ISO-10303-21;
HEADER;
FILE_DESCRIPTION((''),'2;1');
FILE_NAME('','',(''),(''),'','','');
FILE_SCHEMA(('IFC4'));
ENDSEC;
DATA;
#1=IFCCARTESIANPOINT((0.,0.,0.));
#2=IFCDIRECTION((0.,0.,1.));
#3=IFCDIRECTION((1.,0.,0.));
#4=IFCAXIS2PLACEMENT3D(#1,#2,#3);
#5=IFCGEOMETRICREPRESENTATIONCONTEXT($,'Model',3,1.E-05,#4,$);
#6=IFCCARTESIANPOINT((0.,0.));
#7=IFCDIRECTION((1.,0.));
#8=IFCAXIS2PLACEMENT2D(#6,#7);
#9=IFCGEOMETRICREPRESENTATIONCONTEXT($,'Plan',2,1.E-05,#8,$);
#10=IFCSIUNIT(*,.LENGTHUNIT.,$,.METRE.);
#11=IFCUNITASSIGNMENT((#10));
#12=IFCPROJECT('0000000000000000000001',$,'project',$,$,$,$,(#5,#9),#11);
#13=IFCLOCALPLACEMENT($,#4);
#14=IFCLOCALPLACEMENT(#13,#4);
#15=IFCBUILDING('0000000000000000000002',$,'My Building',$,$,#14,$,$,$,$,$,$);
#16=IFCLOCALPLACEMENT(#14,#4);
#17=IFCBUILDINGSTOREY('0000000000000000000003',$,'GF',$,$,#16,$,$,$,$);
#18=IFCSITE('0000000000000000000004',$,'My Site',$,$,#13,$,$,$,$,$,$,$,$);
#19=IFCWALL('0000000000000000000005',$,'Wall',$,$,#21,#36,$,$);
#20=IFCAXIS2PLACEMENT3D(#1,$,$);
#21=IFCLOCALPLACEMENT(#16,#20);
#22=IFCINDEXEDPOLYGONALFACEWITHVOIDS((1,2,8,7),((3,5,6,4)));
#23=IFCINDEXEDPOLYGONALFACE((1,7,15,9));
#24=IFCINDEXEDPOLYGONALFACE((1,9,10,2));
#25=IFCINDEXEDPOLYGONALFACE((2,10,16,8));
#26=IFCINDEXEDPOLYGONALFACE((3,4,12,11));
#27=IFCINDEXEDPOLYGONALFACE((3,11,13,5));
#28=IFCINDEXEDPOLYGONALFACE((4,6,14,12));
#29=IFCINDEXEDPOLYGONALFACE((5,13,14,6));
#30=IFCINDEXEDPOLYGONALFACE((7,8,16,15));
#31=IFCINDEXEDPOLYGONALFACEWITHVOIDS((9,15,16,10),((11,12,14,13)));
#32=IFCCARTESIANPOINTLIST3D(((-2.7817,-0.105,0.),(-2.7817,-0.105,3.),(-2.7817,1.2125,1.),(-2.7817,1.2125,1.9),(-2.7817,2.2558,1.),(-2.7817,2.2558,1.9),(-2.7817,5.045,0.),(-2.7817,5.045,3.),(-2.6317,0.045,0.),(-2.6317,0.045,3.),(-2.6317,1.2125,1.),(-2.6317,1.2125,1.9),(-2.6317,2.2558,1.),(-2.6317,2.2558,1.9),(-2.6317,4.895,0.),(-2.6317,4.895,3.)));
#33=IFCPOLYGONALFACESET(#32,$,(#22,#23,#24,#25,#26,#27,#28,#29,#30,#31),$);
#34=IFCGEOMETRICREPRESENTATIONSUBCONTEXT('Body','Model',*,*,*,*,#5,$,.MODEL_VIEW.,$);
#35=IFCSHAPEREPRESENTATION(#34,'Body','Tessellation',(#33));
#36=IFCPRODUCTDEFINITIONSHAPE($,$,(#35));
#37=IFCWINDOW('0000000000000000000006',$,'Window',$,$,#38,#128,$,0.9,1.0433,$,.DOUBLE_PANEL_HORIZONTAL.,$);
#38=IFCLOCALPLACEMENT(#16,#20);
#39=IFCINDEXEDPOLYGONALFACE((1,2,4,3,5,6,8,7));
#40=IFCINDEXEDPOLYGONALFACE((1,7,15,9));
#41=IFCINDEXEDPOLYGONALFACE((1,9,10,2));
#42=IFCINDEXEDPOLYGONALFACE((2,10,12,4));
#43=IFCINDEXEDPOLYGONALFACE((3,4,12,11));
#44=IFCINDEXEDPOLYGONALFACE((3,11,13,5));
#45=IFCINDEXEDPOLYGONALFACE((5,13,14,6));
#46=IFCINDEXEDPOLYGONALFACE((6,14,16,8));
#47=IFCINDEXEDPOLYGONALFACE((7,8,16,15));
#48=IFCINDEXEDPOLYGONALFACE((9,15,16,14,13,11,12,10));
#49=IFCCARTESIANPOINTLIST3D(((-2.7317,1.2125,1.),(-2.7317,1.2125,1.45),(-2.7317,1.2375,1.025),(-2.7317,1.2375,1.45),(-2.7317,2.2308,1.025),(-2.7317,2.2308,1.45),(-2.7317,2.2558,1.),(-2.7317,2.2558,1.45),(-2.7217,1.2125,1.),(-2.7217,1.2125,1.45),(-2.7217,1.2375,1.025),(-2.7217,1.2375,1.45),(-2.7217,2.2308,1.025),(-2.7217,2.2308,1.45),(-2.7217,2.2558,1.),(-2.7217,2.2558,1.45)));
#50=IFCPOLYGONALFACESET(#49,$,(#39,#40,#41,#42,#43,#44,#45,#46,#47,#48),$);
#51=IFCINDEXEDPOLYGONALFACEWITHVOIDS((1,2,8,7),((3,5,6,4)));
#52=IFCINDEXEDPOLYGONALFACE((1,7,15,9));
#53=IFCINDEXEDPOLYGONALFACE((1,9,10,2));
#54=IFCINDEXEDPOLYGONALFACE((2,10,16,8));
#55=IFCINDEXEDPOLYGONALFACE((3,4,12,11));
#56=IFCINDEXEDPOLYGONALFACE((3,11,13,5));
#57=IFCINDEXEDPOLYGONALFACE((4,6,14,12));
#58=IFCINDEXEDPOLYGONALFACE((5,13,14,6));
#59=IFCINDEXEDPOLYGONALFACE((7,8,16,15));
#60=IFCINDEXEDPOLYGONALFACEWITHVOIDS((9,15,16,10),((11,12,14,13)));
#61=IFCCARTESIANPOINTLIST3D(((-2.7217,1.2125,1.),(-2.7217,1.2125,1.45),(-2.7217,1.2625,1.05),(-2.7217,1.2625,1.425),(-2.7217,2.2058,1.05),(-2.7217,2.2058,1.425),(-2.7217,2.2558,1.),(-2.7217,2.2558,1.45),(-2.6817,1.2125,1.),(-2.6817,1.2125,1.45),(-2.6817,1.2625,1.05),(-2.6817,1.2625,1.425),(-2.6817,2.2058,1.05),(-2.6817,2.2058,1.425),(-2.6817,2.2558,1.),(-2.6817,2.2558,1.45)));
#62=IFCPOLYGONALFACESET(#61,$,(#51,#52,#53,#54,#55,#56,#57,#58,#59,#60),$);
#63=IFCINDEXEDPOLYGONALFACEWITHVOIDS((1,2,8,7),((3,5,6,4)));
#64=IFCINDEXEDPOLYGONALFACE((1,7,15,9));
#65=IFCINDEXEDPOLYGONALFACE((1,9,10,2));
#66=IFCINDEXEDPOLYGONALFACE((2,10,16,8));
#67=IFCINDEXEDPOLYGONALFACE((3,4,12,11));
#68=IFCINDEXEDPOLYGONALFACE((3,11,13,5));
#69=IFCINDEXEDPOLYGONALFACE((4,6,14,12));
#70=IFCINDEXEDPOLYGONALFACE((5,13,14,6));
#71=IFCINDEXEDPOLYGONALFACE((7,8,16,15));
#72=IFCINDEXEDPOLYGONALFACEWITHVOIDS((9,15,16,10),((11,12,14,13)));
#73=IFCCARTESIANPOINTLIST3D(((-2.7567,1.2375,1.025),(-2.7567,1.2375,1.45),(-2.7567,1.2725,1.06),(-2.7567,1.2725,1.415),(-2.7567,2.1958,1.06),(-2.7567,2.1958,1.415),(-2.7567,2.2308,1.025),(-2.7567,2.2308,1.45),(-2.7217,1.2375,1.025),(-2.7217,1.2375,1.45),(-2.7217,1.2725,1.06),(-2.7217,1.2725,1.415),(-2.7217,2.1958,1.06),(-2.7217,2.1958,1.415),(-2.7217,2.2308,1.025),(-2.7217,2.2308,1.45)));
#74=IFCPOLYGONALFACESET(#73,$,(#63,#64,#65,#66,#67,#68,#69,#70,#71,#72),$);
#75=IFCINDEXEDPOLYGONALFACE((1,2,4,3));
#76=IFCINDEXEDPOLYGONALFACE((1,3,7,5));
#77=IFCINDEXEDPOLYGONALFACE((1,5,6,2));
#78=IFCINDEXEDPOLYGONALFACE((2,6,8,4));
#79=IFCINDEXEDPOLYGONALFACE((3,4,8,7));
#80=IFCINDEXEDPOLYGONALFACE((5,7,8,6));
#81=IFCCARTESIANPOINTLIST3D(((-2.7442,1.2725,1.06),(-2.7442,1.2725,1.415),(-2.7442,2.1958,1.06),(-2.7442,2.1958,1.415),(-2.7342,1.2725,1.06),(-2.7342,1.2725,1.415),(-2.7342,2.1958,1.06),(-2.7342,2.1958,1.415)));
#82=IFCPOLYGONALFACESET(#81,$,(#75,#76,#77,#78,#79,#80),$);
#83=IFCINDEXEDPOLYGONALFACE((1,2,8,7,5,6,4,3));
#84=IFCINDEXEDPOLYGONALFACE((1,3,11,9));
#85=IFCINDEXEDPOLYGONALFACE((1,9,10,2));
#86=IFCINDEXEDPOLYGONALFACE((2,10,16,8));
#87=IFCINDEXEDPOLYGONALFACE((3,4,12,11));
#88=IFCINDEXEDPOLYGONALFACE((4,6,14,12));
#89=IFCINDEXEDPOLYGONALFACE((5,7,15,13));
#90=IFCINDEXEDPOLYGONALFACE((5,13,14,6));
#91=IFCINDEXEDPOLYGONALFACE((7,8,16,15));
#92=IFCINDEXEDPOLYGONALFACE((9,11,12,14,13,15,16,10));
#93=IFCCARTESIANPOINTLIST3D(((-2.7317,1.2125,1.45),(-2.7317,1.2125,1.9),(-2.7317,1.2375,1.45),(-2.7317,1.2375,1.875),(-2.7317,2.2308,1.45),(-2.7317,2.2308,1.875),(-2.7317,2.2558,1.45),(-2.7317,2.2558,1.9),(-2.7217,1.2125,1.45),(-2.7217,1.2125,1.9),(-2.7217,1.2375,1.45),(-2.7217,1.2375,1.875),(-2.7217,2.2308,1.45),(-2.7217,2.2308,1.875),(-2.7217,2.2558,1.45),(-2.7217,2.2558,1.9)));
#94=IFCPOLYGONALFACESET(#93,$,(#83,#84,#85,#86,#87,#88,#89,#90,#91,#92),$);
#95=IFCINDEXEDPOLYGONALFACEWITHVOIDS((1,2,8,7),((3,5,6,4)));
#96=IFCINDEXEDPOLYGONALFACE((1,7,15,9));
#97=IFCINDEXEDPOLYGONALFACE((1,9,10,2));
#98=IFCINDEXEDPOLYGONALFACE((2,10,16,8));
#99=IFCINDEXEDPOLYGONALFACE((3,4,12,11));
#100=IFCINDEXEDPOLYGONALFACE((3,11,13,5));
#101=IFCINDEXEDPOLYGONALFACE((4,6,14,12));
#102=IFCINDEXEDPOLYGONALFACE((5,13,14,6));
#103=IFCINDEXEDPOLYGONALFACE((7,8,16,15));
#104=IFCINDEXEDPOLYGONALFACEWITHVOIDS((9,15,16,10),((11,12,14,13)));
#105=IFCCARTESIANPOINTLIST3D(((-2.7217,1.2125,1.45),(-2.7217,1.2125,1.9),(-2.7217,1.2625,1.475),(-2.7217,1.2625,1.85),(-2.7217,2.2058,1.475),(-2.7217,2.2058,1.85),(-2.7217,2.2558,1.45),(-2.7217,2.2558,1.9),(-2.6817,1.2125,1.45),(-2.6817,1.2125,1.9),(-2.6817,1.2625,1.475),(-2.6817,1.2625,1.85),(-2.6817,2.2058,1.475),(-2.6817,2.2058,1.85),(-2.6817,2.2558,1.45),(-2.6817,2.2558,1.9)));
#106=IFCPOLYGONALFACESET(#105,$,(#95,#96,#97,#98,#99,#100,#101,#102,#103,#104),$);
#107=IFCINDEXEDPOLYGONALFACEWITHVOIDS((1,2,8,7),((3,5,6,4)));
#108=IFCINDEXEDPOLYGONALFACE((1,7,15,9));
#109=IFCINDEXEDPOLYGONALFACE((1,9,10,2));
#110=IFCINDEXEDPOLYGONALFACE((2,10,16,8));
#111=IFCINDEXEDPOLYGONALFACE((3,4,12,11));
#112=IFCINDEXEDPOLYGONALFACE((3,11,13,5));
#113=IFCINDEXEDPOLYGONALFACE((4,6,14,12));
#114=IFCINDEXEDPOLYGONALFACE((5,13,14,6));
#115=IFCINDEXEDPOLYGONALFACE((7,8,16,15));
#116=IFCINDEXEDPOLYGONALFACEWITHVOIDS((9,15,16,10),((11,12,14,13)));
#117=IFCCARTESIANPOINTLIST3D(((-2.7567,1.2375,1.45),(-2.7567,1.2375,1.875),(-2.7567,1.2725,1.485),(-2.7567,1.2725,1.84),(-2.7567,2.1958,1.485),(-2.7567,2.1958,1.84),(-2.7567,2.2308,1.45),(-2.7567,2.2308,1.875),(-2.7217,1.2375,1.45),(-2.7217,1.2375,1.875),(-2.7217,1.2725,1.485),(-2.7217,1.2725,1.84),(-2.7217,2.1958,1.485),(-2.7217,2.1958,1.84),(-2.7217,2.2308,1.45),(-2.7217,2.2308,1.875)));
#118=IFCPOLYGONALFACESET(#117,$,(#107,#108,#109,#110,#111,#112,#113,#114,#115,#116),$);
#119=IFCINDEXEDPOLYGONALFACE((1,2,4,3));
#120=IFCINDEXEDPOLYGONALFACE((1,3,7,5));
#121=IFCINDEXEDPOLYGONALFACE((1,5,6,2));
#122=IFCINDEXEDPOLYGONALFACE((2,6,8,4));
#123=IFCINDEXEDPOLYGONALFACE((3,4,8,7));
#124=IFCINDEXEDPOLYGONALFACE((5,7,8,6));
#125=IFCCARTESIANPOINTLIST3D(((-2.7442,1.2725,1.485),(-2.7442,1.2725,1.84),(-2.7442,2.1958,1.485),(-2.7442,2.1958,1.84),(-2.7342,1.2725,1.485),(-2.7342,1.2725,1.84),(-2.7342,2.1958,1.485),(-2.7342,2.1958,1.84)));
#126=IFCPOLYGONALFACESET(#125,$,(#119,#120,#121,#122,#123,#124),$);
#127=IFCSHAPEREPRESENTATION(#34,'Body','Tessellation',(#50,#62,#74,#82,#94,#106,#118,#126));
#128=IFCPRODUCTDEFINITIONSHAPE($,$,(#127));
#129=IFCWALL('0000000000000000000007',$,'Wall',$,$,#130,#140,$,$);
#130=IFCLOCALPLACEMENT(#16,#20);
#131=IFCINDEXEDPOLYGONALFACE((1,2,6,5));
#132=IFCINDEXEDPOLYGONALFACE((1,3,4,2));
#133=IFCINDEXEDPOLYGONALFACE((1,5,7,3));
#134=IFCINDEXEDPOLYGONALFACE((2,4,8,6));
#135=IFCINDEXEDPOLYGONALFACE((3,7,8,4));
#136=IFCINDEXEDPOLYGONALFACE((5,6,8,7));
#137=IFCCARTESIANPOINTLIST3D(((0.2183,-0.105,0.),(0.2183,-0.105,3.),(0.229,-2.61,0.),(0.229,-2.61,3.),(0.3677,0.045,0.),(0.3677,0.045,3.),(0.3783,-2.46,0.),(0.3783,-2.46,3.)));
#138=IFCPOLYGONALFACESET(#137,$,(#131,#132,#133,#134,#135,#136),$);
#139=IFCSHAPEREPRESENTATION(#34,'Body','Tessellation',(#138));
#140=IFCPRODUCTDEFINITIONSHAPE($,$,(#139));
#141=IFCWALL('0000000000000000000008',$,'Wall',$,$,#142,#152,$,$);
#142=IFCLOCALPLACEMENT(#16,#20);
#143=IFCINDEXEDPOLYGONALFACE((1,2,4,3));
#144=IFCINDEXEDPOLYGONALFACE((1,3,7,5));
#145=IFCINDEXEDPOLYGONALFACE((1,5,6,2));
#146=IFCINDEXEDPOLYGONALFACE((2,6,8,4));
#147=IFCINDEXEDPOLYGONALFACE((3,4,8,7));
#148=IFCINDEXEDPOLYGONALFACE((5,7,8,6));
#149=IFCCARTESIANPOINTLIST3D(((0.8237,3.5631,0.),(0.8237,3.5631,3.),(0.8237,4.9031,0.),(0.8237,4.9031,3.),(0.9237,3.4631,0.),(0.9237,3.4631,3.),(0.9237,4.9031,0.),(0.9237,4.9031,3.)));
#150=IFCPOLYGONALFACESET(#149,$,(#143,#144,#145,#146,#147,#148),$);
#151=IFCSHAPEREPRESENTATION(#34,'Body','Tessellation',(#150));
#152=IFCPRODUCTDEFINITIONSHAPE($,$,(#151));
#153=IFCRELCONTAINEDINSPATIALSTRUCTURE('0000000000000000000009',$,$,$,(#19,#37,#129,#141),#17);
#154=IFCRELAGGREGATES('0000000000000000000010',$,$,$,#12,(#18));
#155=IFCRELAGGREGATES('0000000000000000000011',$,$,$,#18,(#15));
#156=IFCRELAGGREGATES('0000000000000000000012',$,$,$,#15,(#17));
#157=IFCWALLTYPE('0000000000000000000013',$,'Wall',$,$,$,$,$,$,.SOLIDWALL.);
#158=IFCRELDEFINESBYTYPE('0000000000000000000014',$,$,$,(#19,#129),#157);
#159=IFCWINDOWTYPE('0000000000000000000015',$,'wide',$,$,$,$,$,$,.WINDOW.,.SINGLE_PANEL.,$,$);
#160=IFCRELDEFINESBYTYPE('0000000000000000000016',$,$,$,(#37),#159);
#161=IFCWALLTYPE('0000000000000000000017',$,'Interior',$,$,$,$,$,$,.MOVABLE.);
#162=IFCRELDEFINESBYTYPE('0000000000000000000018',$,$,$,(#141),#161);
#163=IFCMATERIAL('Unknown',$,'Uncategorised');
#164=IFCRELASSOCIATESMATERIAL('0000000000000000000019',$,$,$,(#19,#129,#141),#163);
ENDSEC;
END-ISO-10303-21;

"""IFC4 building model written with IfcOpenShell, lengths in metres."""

from ifc_helpers import new_model, entity, si_unit, frame, origin_with_axes, origin_2d_with_axis, place, context, subcontext, project, spatial, line, indexed_curve, outline, extrude, shape, source, transform, mapped, material, type_object, type_shapes, element, fill, save


model = new_model("IFC4")

# Units and contexts
model_context = context("Model", 3, precision=1e-05, world=origin_with_axes())
plan_context = context("Plan", 2, precision=1e-05, world=origin_2d_with_axis())
body_context_1 = subcontext(model_context, "Body", "Model", "MODEL_VIEW")
body_context_2 = subcontext(plan_context, "Body", "Plan", "PLAN_VIEW")
ifc_project = project(units=[si_unit("LENGTHUNIT", "METRE")], contexts=[model_context, plan_context])

# Site, building, storey
site_placement = place(None, origin_with_axes())
site = spatial("IfcSite", under=ifc_project, at=site_placement, Name="My Site")
building_placement = place(site_placement, origin_with_axes())
building = spatial("IfcBuilding", under=site, at=building_placement, Name="My Building")
storey_placement = place(building_placement, origin_with_axes())
storey = spatial("IfcBuildingStorey", under=building, at=storey_placement, Name="GF")

# Shared definitions
ifc_material = material(Name="Unknown", Category="Uncategorised")
wall_type_1 = type_object("IfcWallType", Name="Wall", PredefinedType="SOLIDWALL")
shared_shape_1 = source(origin_with_axes(), body_context_1, "Body", "SweptSolid", [
    extrude(outline(indexed_curve([(0.0, 0.0), (1.0433, 0.0), (1.0433, 0.9), (0.0, 0.9)], segments=[line(1, 2, 3, 4, 1)])), frame((0.0, -0.6, 0.0), z_axis=(0.0, -1.0, 0.0), x_axis=(1.0, 0.0, 0.0)), (0.0, 0.0, -1.0), 1.2),
])
window_type_1 = type_object("IfcWindowType", Name="wide", PartitioningType="SINGLE_PANEL", PredefinedType="WINDOW")
shared_shape_2 = source(origin_with_axes(), body_context_1, "Body", "SweptSolid", [
    extrude(outline(indexed_curve([(1.0433, 0.45), (1.0433, 0.0), (0.0, 0.0), (0.0, 0.45), (0.025, 0.45), (0.025, 0.025), (1.0183, 0.025), (1.0183, 0.45)], segments=[line(1, 2, 3, 4, 5, 6, 7, 8, 1)])), frame((0.0, 0.09, 0.0), z_axis=(0.0, -1.0, 0.0), x_axis=(1.0, 0.0, 0.0)), (0.0, 0.0, -1.0), 0.01),
    extrude(outline(indexed_curve([(0.0, 0.0), (1.0433, 0.0), (1.0433, 0.45), (0.0, 0.45)], segments=[line(1, 2, 3, 4, 1)]), holes=[indexed_curve([(0.05, 0.05), (0.9933, 0.05), (0.9933, 0.425), (0.05, 0.425)], segments=[line(1, 2, 3, 4, 1)])]), frame((0.0, 0.05, 0.0), z_axis=(0.0, -1.0, 0.0), x_axis=(1.0, 0.0, 0.0)), (0.0, 0.0, -1.0), 0.04),
    extrude(outline(indexed_curve([(0.0, 0.0), (0.9933, 0.0), (0.9933, 0.425), (0.0, 0.425)], segments=[line(1, 2, 3, 4, 1)]), holes=[indexed_curve([(0.035, 0.035), (0.9583, 0.035), (0.9583, 0.39), (0.035, 0.39)], segments=[line(1, 2, 3, 4, 1)])]), frame((0.025, 0.09, 0.025), z_axis=(0.0, -1.0, 0.0), x_axis=(1.0, 0.0, 0.0)), (0.0, 0.0, -1.0), 0.035),
    extrude(outline(indexed_curve([(0.035, 0.035), (0.9583, 0.035), (0.9583, 0.39), (0.035, 0.39)], segments=[line(1, 2, 3, 4, 1)])), frame((0.025, 0.1025, 0.025), z_axis=(0.0, -1.0, 0.0), x_axis=(1.0, 0.0, 0.0)), (0.0, 0.0, -1.0), 0.01),
    extrude(outline(indexed_curve([(0.0, 0.0), (0.0, 0.45), (1.0433, 0.45), (1.0433, 0.0), (1.0183, 0.0), (1.0183, 0.425), (0.025, 0.425), (0.025, 0.0)], segments=[line(1, 2, 3, 4, 5, 6, 7, 8, 1)])), frame((0.0, 0.09, 0.45), z_axis=(0.0, -1.0, 0.0), x_axis=(1.0, 0.0, 0.0)), (0.0, 0.0, -1.0), 0.01),
    extrude(outline(indexed_curve([(0.0, 0.0), (1.0433, 0.0), (1.0433, 0.45), (0.0, 0.45)], segments=[line(1, 2, 3, 4, 1)]), holes=[indexed_curve([(0.05, 0.025), (0.9933, 0.025), (0.9933, 0.4), (0.05, 0.4)], segments=[line(1, 2, 3, 4, 1)])]), frame((0.0, 0.05, 0.45), z_axis=(0.0, -1.0, 0.0), x_axis=(1.0, 0.0, 0.0)), (0.0, 0.0, -1.0), 0.04),
    extrude(outline(indexed_curve([(0.0, 0.0), (0.9933, 0.0), (0.9933, 0.425), (0.0, 0.425)], segments=[line(1, 2, 3, 4, 1)]), holes=[indexed_curve([(0.035, 0.035), (0.9583, 0.035), (0.9583, 0.39), (0.035, 0.39)], segments=[line(1, 2, 3, 4, 1)])]), frame((0.025, 0.09, 0.45), z_axis=(0.0, -1.0, 0.0), x_axis=(1.0, 0.0, 0.0)), (0.0, 0.0, -1.0), 0.035),
    extrude(outline(indexed_curve([(0.035, 0.035), (0.9583, 0.035), (0.9583, 0.39), (0.035, 0.39)], segments=[line(1, 2, 3, 4, 1)])), frame((0.025, 0.1025, 0.45), z_axis=(0.0, -1.0, 0.0), x_axis=(1.0, 0.0, 0.0)), (0.0, 0.0, -1.0), 0.01),
])
shared_shape_3 = source(origin_with_axes(), body_context_2, "Body", "Curve2D", [
    entity("IfcIndexedPolyCurve", entity("IfcCartesianPointList2D", [[0.05, 0.05], [0.9933, 0.05]])),
    entity("IfcIndexedPolyCurve", entity("IfcCartesianPointList2D", [[0.0, 0.1], [0.025, 0.1], [0.025, 0.09], [0.05, 0.09], [0.05, 0.05], [0.0, 0.05]]), [entity("IfcLineIndex", [1, 2, 3, 4, 5, 6, 1])]),
    entity("IfcIndexedPolyCurve", entity("IfcCartesianPointList2D", [[1.0433, 0.1], [1.0183, 0.1], [1.0183, 0.09], [0.9933, 0.09], [0.9933, 0.05], [1.0433, 0.05]]), [entity("IfcLineIndex", [1, 2, 3, 4, 5, 6, 1])]),
    entity("IfcIndexedPolyCurve", entity("IfcCartesianPointList2D", [[0.025, 0.09], [0.06, 0.09], [0.06, 0.125], [0.025, 0.125]]), [entity("IfcLineIndex", [1, 2, 3, 4, 1])]),
    entity("IfcIndexedPolyCurve", entity("IfcCartesianPointList2D", [[1.0183, 0.09], [0.9833, 0.09], [0.9833, 0.125], [1.0183, 0.125]]), [entity("IfcLineIndex", [1, 2, 3, 4, 1])]),
    entity("IfcIndexedPolyCurve", entity("IfcCartesianPointList2D", [[0.06, 0.09], [0.9833, 0.09]])),
    entity("IfcIndexedPolyCurve", entity("IfcCartesianPointList2D", [[0.06, 0.125], [0.9833, 0.125]])),
    entity("IfcIndexedPolyCurve", entity("IfcCartesianPointList2D", [[0.06, 0.1075], [0.9833, 0.1075]])),
])
type_shapes(window_type_1, [shared_shape_2, shared_shape_3])

# Wall, opening, window
wall_1_placement = place(storey_placement, frame((-2.7817, 5.045, 0.0), z_axis=(0.0, 0.0, 1.0), x_axis=(0.0, -1.0, 0.0)))
wall_1 = element("IfcWall", 1, at=wall_1_placement, inside=storey, type_object=wall_type_1, material=ifc_material, Name="Wall", context=body_context_1, shape_type="SweptSolid", body=[
    extrude(outline(indexed_curve([(0.0, 0.0), (0.15, 0.15), (5.0, 0.15), (5.15, 0.0)], segments=[line(1, 2, 3, 4, 1)])), origin_with_axes(), (0.0, 0.0, 1.0), 3.0),
])
opening_1_placement = place(wall_1_placement, frame((3.8324, 0.15, 1.0), z_axis=(0.0, 0.0, 1.0), x_axis=(-1.0, 0.0, 0.0)))
opening_1 = element("IfcOpeningElement", 2, at=opening_1_placement, cuts=wall_1, PredefinedType="OPENING", context=body_context_1, shape_type="MappedRepresentation", body=[
    mapped(shared_shape_1, transform((0.0, 0.0, 0.0), x_axis=(1.0, 0.0, 0.0), y_axis=(0.0, 1.0, 0.0), z_axis=(0.0, 0.0, 1.0), scale=1.0)),
])
window_1_placement = place(opening_1_placement, frame((0.0, 0.0, 0.0), z_axis=(0.0, 0.0, 1.0), x_axis=(1.0, 0.0, 0.0)))
window_1 = element("IfcWindow", 3, at=window_1_placement, inside=storey, type_object=window_type_1, Name="Window", OverallHeight=0.9, OverallWidth=1.0433, PartitioningType="DOUBLE_PANEL_HORIZONTAL", shapes=[
    shape(body_context_1, "Body", "MappedRepresentation", [mapped(shared_shape_2, transform((0.0, 0.0, 0.0), x_axis=(1.0, 0.0, 0.0), y_axis=(0.0, 1.0, 0.0), z_axis=(0.0, 0.0, 1.0), scale=1.0))]),
    shape(body_context_2, "Body", "MappedRepresentation", [mapped(shared_shape_3, transform((0.0, 0.0, 0.0), x_axis=(1.0, 0.0, 0.0), y_axis=(0.0, 1.0, 0.0), z_axis=(0.0, 0.0, 1.0), scale=1.0))]),
])
fill(opening_1, window_1)

# Walls
wall_2_placement = place(storey_placement, frame((0.2183, -0.105, 0.0), z_axis=(0.0, 0.0, 1.0), x_axis=(0.004245, -0.999991, 0.0)))
element("IfcWall", 4, at=wall_2_placement, inside=storey, type_object=wall_type_1, material=ifc_material, Name="Wall", context=body_context_1, shape_type="SweptSolid", body=[
    extrude(outline(indexed_curve([(0.0, 0.0), (-0.1494, 0.15), (2.3557, 0.15), (2.505, 0.0)], segments=[line(1, 2, 3, 4, 1)])), origin_with_axes(), (0.0, 0.0, 1.0), 3.0),
])
wall_type_2 = type_object("IfcWallType", Name="Interior", PredefinedType="MOVABLE")
wall_3_placement = place(storey_placement, frame((0.8237, 4.9031, 0.0), z_axis=(0.0, 0.0, 1.0), x_axis=(0.0, -1.0, 0.0)))
element("IfcWall", 5, at=wall_3_placement, inside=storey, type_object=wall_type_2, material=ifc_material, Name="Wall", context=body_context_1, shape_type="SweptSolid", body=[
    extrude(outline(indexed_curve([(0.0, 0.0), (0.0, 0.1), (1.44, 0.1), (1.34, 0.0)], segments=[line(1, 2, 3, 4, 1)])), origin_with_axes(), (0.0, 0.0, 1.0), 3.0),
])

save(model, "model.ifc")
